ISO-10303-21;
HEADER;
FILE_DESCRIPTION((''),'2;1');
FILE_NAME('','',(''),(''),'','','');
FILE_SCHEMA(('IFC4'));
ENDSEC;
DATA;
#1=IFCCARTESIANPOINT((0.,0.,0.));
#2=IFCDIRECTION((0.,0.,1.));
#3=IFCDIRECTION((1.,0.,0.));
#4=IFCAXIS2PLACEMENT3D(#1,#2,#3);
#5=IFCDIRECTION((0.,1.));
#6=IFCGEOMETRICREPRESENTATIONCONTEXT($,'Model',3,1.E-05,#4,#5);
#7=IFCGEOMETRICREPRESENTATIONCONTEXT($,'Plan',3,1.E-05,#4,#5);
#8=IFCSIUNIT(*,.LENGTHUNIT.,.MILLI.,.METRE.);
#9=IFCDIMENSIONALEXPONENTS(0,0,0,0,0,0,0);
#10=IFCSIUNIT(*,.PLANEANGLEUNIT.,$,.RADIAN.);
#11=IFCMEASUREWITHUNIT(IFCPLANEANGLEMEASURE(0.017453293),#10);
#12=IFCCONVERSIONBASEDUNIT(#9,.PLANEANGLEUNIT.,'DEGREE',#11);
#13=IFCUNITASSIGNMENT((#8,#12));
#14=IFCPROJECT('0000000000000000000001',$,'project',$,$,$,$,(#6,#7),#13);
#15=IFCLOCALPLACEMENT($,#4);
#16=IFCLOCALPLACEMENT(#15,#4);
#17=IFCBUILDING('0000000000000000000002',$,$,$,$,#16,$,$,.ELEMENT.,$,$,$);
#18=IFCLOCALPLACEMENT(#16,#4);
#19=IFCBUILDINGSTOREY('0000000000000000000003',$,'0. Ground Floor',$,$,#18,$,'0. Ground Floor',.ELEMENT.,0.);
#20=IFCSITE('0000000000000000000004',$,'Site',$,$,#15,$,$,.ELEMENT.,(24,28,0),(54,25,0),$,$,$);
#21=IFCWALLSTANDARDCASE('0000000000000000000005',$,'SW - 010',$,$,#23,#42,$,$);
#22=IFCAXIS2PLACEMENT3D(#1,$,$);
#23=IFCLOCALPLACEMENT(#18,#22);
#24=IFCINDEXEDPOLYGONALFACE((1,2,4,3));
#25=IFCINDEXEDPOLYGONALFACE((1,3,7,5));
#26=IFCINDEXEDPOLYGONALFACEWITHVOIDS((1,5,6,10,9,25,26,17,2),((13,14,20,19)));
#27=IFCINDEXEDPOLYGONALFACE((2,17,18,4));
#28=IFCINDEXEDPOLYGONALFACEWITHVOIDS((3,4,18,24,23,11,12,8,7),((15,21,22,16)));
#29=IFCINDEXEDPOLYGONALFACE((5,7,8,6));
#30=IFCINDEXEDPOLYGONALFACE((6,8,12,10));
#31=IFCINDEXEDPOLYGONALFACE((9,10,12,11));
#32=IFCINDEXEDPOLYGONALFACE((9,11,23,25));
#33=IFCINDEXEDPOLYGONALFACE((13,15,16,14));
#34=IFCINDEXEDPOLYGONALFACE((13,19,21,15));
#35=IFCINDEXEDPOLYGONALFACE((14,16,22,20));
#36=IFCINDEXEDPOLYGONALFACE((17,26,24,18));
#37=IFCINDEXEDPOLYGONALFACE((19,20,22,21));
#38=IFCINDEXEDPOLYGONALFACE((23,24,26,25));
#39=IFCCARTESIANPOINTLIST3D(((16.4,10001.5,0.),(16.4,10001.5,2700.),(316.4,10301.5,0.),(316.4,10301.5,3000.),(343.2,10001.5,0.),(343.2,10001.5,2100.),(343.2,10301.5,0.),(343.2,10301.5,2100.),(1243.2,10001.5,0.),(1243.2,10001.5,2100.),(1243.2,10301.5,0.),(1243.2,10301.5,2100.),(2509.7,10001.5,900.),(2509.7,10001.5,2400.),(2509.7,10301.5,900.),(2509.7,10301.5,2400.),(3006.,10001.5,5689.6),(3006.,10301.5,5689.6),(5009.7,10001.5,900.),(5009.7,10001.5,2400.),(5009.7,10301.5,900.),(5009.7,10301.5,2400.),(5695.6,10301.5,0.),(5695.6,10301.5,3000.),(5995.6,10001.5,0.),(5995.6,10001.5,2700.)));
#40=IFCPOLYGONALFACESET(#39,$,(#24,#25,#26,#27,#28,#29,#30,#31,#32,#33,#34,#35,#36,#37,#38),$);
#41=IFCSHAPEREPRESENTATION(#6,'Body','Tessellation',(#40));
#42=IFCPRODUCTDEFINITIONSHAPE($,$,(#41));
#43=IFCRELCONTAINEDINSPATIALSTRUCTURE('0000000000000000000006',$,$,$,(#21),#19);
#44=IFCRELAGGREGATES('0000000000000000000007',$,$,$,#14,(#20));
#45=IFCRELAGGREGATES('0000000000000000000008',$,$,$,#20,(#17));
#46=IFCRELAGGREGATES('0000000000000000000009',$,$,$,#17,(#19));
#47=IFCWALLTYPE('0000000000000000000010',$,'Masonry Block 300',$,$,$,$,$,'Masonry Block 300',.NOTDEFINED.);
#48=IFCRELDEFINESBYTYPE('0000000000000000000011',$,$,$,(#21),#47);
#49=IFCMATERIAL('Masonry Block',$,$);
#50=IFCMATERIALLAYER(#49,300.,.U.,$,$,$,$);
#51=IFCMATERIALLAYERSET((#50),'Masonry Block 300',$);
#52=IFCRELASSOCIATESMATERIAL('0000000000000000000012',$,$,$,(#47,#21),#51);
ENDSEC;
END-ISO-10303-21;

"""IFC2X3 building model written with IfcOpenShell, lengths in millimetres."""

from ifc_helpers import new_model, entity, si_unit, converted_unit, direction, frame, frame_2d, origin_with_axes, place, context, project, spatial, polyline, rectangle, outline, extrude, clip, bounded_halfspace, material, layer, layer_set, layer_usage, type_object, element, save


model = new_model("IFC2X3")

# Units and contexts
plan_context = context("Plan", 3, precision=1e-05, world=origin_with_axes(), true_north=direction((0.0, 1.0)))
model_context = context("Model", 3, precision=1e-05, world=origin_with_axes(), true_north=direction((0.0, 1.0)))
ifc_project = project(units=[si_unit("LENGTHUNIT", "METRE", prefix="MILLI"), converted_unit("PLANEANGLEUNIT", "DEGREE", entity("IfcPlaneAngleMeasure", 0.017453293), si_unit("PLANEANGLEUNIT", "RADIAN"), dimensions=[0, 0, 0, 0, 0, 0, 0])], contexts=[model_context, plan_context])

# Site, building, storey
site_placement = place(None, origin_with_axes())
site = spatial("IfcSite", under=ifc_project, at=site_placement, Name="Site", CompositionType="ELEMENT", RefLatitude=(24, 28, 0), RefLongitude=(54, 25, 0))
building_placement = place(site_placement, origin_with_axes())
building = spatial("IfcBuilding", under=site, at=building_placement, CompositionType="ELEMENT")
storey_placement = place(building_placement, origin_with_axes())
storey = spatial("IfcBuildingStorey", under=building, at=storey_placement, Name="0. Ground Floor", LongName="0. Ground Floor", CompositionType="ELEMENT", Elevation=0.0)

# Shared definitions
ifc_material_1 = material(Name="Masonry Block")

# Shared definitions
ifc_layer_1 = layer(ifc_material_1, 300.0, ventilated="UNKNOWN")
ifc_layer_set_1 = layer_set([ifc_layer_1], Name="Masonry Block 300")
wall_type_1 = type_object("IfcWallType", Name="Masonry Block 300", ElementType="Masonry Block 300", PredefinedType="NOTDEFINED", material=ifc_layer_set_1)

# Wall, openings
ifc_layer_usage_1 = layer_usage(ifc_layer_set_1, "AXIS2", "POSITIVE", 0.0)
wall_1_placement = place(storey_placement, frame((16.4, 10001.5, 0.0), z_axis=(0.0, 0.0, 1.0), x_axis=(1.0, 0.0, 0.0)))
wall_1 = element("IfcWallStandardCase", 1, at=wall_1_placement, inside=storey, type_object=wall_type_1, material=ifc_layer_usage_1, Name="SW - 010", context=model_context, shape_type="Clipping", body=[
    clip(clip(extrude(outline(polyline([(0.0, 0.0), (5979.1, 0.0), (5679.1, 300.0), (300.0, 300.0), (0.0, 0.0)])), origin_with_axes(), (0.0, 0.0, 1.0), 6000.0), bounded_halfspace(frame((-1350.0, 0.0, 1350.0), z_axis=(0.707107, 0.0, -0.707107), x_axis=(0.0, 1.0, 0.0)), True, origin_with_axes(), polyline([(2989.6, -150.0), (2989.6, 450.0), (-10.0, 450.0), (-10.0, -150.0), (2989.6, -150.0)]))), bounded_halfspace(frame((4339.6, 0.0, 4339.6), z_axis=(-0.707107, 0.0, -0.707107), x_axis=(0.0, 1.0, 0.0)), True, origin_with_axes(), polyline([(2989.6, -150.0), (2989.6, 450.0), (5989.1, 450.0), (5989.1, -150.0), (2989.6, -150.0)]))),
])
opening_1_placement = place(wall_1_placement, frame((3743.3, 0.0, 900.0), z_axis=(0.0, 0.0, 1.0), x_axis=(1.0, 0.0, 0.0)))
element("IfcOpeningElement", 2, at=opening_1_placement, cuts=wall_1, ObjectType="Opening", context=model_context, shape_type="SweptSolid", body=[
    extrude(rectangle(XDim=2500.0, YDim=1500.0, at=frame_2d((0.0, 750.0), x_axis=(-1.0, 0.0))), frame((0.0, 0.0, 0.0), z_axis=(0.0, 1.0, 0.0), x_axis=(-1.0, 0.0, 0.0)), (0.0, 0.0, 1.0), 300.0),
])
opening_2_placement = place(wall_1_placement, frame((776.8, 0.0, 0.0), z_axis=(0.0, 0.0, 1.0), x_axis=(1.0, 0.0, 0.0)))
element("IfcOpeningElement", 3, at=opening_2_placement, cuts=wall_1, ObjectType="Opening", context=model_context, shape_type="SweptSolid", body=[
    extrude(rectangle(XDim=900.0, YDim=2100.0, at=frame_2d((0.0, 1050.0), x_axis=(-1.0, 0.0))), frame((0.0, 0.0, 0.0), z_axis=(0.0, 1.0, 0.0), x_axis=(-1.0, 0.0, 0.0)), (0.0, 0.0, 1.0), 300.0),
])

save(model, "model.ifc")
